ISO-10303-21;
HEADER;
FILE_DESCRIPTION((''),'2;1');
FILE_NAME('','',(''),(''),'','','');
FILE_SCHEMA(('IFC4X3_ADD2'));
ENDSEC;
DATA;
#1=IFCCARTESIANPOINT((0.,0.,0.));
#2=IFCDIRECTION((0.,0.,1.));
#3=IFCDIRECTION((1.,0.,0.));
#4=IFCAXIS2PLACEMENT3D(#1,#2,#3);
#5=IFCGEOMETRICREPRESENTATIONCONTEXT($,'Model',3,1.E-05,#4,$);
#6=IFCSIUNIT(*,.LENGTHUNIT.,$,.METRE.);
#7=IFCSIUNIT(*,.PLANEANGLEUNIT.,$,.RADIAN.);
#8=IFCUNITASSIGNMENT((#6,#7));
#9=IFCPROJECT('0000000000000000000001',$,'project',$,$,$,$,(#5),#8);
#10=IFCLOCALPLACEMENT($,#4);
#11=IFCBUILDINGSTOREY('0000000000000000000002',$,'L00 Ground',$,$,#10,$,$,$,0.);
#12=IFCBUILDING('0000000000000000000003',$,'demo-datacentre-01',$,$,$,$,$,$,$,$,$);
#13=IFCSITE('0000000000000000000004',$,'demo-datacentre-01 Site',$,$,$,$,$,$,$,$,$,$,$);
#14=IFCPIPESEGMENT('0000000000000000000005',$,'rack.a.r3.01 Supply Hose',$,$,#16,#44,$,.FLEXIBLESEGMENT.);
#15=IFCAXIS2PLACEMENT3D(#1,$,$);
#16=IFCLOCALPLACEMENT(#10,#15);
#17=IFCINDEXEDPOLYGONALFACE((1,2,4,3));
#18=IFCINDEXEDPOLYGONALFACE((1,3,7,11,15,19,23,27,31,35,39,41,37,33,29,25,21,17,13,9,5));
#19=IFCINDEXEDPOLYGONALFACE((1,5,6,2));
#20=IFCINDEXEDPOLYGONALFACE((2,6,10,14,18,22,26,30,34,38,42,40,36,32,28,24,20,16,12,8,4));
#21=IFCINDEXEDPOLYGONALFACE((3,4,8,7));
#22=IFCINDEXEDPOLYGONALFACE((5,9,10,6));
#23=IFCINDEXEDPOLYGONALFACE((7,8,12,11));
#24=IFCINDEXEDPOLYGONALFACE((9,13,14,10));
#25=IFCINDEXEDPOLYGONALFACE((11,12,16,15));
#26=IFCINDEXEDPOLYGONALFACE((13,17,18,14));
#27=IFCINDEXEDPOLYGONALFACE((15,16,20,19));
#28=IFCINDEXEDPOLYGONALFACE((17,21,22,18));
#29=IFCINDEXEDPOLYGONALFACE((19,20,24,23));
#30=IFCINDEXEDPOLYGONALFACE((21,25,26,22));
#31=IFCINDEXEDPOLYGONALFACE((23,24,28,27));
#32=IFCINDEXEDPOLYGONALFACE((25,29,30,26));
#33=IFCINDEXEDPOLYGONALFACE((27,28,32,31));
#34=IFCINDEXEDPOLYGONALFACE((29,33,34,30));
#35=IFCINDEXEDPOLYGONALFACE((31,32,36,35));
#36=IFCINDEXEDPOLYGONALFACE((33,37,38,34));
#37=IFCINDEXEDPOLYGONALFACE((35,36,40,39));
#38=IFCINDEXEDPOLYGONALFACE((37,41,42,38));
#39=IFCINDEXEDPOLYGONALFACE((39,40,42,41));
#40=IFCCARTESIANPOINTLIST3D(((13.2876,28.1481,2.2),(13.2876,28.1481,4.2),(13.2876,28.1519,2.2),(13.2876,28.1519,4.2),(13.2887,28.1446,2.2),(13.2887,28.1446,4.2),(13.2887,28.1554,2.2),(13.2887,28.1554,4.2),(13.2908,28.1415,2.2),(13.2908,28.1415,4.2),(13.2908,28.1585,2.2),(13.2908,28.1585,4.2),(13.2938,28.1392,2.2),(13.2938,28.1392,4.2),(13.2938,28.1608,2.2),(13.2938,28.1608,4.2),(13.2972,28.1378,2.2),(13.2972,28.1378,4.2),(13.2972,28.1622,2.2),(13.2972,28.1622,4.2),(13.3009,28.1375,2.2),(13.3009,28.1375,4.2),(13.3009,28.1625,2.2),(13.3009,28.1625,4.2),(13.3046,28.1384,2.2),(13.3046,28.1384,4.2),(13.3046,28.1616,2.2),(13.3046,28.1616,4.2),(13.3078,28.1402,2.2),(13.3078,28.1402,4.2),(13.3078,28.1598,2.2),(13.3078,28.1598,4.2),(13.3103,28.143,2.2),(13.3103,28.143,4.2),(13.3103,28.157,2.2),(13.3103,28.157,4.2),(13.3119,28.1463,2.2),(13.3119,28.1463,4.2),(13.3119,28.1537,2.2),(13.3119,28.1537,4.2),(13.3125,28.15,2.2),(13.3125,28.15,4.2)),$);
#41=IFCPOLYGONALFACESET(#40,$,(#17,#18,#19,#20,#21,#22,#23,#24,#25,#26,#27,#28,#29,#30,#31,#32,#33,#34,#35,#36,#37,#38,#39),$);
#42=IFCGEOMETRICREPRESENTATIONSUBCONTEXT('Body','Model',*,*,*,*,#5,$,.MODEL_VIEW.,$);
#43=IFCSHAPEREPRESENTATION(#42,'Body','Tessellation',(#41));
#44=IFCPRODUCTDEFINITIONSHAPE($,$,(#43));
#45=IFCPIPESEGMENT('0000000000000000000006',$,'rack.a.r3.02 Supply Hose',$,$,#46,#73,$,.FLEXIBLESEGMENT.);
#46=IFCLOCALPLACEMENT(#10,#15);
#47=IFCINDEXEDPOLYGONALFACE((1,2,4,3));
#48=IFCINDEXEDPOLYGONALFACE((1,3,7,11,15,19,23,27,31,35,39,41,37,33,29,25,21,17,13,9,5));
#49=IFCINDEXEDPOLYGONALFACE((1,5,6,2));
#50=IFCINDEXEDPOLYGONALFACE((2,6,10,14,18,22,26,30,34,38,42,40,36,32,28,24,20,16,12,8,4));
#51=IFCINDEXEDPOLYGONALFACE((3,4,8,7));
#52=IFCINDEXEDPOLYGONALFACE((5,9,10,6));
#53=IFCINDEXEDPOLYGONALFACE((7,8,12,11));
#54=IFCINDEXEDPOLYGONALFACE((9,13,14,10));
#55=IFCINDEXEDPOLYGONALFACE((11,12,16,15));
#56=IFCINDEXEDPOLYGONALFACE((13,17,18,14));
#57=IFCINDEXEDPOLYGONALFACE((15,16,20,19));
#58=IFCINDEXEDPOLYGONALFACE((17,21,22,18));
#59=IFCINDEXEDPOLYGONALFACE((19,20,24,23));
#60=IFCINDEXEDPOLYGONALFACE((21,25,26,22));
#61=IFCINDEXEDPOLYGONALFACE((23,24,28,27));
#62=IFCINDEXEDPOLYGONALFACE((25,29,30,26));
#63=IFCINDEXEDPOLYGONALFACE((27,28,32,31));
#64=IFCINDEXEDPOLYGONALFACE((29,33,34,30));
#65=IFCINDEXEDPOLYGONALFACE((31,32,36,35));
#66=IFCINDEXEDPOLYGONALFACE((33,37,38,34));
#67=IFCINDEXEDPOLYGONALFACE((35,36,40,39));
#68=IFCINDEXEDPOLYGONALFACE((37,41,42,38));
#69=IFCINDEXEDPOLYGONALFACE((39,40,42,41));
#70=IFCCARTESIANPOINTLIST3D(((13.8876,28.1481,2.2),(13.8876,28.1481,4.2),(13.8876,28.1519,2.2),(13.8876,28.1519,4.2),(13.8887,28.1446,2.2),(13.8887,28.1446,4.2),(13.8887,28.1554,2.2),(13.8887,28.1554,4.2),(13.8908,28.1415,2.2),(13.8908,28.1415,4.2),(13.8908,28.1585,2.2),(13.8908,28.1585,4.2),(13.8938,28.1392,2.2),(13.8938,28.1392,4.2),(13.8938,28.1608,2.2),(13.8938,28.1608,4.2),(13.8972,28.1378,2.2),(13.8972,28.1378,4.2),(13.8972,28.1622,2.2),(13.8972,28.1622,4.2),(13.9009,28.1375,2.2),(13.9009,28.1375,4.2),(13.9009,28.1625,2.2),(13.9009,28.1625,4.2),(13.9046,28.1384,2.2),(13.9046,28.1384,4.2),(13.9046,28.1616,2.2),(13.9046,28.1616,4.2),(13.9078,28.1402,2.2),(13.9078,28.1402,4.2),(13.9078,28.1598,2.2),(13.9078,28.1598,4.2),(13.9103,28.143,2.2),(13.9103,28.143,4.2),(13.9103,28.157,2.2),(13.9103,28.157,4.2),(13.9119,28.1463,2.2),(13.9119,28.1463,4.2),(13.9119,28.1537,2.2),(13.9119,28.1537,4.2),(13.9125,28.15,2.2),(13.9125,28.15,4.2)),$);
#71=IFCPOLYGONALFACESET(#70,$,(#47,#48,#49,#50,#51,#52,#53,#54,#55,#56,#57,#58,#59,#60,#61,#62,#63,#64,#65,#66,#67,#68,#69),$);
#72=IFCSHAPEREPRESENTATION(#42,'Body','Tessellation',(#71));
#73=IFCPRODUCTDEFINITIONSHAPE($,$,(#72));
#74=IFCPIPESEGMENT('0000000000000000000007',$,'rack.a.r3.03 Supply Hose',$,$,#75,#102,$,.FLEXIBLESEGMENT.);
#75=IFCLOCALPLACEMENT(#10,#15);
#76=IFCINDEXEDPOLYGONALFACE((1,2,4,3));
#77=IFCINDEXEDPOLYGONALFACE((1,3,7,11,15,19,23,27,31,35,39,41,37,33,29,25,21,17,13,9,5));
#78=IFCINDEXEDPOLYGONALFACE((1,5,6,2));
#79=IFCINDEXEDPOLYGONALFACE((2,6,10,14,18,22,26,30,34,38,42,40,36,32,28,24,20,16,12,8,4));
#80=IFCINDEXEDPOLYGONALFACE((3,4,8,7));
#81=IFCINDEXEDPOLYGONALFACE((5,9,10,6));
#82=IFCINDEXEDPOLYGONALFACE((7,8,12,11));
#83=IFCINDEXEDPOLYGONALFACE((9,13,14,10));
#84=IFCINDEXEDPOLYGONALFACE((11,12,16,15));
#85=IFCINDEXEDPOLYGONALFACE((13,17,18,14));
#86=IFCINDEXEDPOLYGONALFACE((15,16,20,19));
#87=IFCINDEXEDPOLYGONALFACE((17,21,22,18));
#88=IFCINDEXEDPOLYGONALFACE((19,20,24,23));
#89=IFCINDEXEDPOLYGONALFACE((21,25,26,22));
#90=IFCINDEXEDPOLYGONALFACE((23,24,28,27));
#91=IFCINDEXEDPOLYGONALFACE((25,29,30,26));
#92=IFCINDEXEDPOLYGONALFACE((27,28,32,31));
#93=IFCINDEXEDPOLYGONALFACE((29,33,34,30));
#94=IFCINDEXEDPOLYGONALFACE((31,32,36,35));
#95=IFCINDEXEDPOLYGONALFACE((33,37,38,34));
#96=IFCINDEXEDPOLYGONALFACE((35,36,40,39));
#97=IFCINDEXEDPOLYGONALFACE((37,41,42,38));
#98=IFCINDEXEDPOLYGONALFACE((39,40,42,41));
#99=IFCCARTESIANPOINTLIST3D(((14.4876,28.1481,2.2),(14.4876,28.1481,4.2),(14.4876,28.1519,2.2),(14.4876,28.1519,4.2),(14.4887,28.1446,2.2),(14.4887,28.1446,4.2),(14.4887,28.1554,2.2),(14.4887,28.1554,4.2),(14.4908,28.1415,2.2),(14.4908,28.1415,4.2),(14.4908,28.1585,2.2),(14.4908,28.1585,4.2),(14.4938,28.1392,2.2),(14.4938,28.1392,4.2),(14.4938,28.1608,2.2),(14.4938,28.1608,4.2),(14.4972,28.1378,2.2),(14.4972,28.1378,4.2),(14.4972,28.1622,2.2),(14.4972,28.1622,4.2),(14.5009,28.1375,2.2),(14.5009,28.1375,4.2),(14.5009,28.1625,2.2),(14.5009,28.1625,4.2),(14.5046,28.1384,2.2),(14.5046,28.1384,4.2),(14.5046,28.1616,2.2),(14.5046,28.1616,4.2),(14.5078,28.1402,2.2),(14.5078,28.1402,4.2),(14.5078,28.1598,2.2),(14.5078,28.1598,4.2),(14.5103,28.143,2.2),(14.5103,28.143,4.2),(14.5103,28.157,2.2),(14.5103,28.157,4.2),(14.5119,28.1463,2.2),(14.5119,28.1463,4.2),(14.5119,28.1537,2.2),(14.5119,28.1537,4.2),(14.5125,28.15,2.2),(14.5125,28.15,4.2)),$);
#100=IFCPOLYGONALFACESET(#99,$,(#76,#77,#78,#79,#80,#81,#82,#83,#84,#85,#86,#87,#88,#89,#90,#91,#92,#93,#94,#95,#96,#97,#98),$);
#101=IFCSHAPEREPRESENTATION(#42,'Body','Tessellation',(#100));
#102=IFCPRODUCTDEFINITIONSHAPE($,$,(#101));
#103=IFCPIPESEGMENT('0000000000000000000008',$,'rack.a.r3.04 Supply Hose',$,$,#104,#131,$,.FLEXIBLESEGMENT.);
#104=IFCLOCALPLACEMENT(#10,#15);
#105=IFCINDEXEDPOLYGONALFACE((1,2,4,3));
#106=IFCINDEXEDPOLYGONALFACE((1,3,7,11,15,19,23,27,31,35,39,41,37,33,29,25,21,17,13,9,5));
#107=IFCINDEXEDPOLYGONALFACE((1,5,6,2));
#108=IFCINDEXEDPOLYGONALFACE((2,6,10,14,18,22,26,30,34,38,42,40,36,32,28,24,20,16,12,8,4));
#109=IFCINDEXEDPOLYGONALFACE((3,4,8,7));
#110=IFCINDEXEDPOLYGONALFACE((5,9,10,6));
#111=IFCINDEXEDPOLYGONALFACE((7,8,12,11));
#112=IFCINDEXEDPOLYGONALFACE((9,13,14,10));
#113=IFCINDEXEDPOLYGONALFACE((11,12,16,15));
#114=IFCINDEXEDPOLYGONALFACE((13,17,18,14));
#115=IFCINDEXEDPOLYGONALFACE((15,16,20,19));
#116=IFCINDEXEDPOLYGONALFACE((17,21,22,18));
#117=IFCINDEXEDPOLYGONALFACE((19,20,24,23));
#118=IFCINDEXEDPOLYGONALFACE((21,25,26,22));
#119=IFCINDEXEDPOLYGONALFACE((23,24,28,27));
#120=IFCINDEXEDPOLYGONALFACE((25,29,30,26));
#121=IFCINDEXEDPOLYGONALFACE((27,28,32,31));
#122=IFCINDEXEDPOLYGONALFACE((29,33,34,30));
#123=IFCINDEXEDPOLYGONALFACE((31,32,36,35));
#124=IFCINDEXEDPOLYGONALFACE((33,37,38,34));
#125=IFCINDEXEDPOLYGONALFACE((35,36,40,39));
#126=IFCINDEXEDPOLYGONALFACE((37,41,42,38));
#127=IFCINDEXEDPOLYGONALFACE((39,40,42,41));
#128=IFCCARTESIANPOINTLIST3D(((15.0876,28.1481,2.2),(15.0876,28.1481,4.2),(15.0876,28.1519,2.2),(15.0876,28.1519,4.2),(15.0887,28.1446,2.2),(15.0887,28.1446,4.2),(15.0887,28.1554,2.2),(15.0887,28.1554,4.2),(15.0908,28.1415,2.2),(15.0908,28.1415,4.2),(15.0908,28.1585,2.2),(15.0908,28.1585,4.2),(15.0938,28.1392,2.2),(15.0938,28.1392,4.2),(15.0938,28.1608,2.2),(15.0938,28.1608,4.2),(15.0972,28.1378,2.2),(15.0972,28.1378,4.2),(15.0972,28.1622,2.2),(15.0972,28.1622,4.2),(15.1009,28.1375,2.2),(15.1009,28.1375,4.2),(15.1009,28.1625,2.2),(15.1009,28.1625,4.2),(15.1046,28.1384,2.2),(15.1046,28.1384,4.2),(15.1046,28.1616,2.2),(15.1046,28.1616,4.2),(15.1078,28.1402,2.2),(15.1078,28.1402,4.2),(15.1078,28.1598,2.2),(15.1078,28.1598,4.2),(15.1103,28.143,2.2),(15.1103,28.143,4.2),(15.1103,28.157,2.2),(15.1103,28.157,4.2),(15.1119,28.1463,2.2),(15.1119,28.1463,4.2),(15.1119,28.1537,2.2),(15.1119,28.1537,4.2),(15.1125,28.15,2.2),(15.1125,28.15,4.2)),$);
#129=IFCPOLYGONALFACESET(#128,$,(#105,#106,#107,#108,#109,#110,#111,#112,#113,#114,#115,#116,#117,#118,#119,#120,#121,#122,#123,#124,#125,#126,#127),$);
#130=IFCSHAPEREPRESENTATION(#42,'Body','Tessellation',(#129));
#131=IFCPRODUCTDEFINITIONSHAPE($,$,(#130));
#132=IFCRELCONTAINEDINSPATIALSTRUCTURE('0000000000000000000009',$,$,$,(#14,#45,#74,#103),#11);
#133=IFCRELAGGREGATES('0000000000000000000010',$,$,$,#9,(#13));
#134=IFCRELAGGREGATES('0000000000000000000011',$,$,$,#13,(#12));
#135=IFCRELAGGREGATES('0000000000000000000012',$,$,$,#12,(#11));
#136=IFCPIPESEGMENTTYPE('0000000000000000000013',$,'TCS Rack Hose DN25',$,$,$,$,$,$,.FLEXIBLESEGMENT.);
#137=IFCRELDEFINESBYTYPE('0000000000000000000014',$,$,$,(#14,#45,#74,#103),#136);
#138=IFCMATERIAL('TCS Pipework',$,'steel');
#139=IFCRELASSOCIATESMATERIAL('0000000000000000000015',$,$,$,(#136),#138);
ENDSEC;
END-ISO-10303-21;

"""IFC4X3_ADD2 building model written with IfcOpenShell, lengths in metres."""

from ifc_helpers import new_model, si_unit, frame, origin_with_axes, place, context, subcontext, project, spatial, circle, extrude, material, type_object, element, save


model = new_model("IFC4X3_ADD2")

# Units and contexts
model_context = context("Model", 3, precision=1e-05, world=origin_with_axes())
body_context = subcontext(model_context, "Body", "Model", "MODEL_VIEW")
ifc_project = project(units=[si_unit("LENGTHUNIT", "METRE"), si_unit("PLANEANGLEUNIT", "RADIAN")], contexts=[model_context])

# Site, building, storey
site = spatial("IfcSite", under=ifc_project, Name="demo-datacentre-01 Site")
building = spatial("IfcBuilding", under=site, Name="demo-datacentre-01")
storey_placement = place(None, origin_with_axes())
storey = spatial("IfcBuildingStorey", under=building, at=storey_placement, Name="L00 Ground", Elevation=0.0)

# Shared definitions
ifc_material = material(Name="TCS Pipework", Category="steel")

# Pipe segments
pipe_segment_type_1 = type_object("IfcPipeSegmentType", Name="TCS Rack Hose DN25", PredefinedType="FLEXIBLESEGMENT", material=ifc_material)
for number, where, z_axis, x_axis, name in (
    (1, (13.3, 28.15, 4.2), (0.0, 0.0, -1.0), (1.0, 0.0, 0.0), "rack.a.r3.01 Supply Hose"),
    (2, (13.9, 28.15, 4.2), (0.0, 0.0, -1.0), (1.0, 0.0, 0.0), "rack.a.r3.02 Supply Hose"),
    (3, (14.5, 28.15, 4.2), (0.0, 0.0, -1.0), (1.0, 0.0, 0.0), "rack.a.r3.03 Supply Hose"),
    (4, (15.1, 28.15, 4.2), (0.0, 0.0, -1.0), (1.0, 0.0, 0.0), "rack.a.r3.04 Supply Hose"),
):
    element("IfcPipeSegment", number, at=place(storey_placement, frame(where, z_axis=z_axis, x_axis=x_axis)), inside=storey, type_object=pipe_segment_type_1, Name=name, PredefinedType="FLEXIBLESEGMENT", context=body_context, shape_type="SweptSolid", body=[
        extrude(circle(Radius=0.0125), origin_with_axes(), (0.0, 0.0, 1.0), 2.0),
    ])

save(model, "model.ifc")
